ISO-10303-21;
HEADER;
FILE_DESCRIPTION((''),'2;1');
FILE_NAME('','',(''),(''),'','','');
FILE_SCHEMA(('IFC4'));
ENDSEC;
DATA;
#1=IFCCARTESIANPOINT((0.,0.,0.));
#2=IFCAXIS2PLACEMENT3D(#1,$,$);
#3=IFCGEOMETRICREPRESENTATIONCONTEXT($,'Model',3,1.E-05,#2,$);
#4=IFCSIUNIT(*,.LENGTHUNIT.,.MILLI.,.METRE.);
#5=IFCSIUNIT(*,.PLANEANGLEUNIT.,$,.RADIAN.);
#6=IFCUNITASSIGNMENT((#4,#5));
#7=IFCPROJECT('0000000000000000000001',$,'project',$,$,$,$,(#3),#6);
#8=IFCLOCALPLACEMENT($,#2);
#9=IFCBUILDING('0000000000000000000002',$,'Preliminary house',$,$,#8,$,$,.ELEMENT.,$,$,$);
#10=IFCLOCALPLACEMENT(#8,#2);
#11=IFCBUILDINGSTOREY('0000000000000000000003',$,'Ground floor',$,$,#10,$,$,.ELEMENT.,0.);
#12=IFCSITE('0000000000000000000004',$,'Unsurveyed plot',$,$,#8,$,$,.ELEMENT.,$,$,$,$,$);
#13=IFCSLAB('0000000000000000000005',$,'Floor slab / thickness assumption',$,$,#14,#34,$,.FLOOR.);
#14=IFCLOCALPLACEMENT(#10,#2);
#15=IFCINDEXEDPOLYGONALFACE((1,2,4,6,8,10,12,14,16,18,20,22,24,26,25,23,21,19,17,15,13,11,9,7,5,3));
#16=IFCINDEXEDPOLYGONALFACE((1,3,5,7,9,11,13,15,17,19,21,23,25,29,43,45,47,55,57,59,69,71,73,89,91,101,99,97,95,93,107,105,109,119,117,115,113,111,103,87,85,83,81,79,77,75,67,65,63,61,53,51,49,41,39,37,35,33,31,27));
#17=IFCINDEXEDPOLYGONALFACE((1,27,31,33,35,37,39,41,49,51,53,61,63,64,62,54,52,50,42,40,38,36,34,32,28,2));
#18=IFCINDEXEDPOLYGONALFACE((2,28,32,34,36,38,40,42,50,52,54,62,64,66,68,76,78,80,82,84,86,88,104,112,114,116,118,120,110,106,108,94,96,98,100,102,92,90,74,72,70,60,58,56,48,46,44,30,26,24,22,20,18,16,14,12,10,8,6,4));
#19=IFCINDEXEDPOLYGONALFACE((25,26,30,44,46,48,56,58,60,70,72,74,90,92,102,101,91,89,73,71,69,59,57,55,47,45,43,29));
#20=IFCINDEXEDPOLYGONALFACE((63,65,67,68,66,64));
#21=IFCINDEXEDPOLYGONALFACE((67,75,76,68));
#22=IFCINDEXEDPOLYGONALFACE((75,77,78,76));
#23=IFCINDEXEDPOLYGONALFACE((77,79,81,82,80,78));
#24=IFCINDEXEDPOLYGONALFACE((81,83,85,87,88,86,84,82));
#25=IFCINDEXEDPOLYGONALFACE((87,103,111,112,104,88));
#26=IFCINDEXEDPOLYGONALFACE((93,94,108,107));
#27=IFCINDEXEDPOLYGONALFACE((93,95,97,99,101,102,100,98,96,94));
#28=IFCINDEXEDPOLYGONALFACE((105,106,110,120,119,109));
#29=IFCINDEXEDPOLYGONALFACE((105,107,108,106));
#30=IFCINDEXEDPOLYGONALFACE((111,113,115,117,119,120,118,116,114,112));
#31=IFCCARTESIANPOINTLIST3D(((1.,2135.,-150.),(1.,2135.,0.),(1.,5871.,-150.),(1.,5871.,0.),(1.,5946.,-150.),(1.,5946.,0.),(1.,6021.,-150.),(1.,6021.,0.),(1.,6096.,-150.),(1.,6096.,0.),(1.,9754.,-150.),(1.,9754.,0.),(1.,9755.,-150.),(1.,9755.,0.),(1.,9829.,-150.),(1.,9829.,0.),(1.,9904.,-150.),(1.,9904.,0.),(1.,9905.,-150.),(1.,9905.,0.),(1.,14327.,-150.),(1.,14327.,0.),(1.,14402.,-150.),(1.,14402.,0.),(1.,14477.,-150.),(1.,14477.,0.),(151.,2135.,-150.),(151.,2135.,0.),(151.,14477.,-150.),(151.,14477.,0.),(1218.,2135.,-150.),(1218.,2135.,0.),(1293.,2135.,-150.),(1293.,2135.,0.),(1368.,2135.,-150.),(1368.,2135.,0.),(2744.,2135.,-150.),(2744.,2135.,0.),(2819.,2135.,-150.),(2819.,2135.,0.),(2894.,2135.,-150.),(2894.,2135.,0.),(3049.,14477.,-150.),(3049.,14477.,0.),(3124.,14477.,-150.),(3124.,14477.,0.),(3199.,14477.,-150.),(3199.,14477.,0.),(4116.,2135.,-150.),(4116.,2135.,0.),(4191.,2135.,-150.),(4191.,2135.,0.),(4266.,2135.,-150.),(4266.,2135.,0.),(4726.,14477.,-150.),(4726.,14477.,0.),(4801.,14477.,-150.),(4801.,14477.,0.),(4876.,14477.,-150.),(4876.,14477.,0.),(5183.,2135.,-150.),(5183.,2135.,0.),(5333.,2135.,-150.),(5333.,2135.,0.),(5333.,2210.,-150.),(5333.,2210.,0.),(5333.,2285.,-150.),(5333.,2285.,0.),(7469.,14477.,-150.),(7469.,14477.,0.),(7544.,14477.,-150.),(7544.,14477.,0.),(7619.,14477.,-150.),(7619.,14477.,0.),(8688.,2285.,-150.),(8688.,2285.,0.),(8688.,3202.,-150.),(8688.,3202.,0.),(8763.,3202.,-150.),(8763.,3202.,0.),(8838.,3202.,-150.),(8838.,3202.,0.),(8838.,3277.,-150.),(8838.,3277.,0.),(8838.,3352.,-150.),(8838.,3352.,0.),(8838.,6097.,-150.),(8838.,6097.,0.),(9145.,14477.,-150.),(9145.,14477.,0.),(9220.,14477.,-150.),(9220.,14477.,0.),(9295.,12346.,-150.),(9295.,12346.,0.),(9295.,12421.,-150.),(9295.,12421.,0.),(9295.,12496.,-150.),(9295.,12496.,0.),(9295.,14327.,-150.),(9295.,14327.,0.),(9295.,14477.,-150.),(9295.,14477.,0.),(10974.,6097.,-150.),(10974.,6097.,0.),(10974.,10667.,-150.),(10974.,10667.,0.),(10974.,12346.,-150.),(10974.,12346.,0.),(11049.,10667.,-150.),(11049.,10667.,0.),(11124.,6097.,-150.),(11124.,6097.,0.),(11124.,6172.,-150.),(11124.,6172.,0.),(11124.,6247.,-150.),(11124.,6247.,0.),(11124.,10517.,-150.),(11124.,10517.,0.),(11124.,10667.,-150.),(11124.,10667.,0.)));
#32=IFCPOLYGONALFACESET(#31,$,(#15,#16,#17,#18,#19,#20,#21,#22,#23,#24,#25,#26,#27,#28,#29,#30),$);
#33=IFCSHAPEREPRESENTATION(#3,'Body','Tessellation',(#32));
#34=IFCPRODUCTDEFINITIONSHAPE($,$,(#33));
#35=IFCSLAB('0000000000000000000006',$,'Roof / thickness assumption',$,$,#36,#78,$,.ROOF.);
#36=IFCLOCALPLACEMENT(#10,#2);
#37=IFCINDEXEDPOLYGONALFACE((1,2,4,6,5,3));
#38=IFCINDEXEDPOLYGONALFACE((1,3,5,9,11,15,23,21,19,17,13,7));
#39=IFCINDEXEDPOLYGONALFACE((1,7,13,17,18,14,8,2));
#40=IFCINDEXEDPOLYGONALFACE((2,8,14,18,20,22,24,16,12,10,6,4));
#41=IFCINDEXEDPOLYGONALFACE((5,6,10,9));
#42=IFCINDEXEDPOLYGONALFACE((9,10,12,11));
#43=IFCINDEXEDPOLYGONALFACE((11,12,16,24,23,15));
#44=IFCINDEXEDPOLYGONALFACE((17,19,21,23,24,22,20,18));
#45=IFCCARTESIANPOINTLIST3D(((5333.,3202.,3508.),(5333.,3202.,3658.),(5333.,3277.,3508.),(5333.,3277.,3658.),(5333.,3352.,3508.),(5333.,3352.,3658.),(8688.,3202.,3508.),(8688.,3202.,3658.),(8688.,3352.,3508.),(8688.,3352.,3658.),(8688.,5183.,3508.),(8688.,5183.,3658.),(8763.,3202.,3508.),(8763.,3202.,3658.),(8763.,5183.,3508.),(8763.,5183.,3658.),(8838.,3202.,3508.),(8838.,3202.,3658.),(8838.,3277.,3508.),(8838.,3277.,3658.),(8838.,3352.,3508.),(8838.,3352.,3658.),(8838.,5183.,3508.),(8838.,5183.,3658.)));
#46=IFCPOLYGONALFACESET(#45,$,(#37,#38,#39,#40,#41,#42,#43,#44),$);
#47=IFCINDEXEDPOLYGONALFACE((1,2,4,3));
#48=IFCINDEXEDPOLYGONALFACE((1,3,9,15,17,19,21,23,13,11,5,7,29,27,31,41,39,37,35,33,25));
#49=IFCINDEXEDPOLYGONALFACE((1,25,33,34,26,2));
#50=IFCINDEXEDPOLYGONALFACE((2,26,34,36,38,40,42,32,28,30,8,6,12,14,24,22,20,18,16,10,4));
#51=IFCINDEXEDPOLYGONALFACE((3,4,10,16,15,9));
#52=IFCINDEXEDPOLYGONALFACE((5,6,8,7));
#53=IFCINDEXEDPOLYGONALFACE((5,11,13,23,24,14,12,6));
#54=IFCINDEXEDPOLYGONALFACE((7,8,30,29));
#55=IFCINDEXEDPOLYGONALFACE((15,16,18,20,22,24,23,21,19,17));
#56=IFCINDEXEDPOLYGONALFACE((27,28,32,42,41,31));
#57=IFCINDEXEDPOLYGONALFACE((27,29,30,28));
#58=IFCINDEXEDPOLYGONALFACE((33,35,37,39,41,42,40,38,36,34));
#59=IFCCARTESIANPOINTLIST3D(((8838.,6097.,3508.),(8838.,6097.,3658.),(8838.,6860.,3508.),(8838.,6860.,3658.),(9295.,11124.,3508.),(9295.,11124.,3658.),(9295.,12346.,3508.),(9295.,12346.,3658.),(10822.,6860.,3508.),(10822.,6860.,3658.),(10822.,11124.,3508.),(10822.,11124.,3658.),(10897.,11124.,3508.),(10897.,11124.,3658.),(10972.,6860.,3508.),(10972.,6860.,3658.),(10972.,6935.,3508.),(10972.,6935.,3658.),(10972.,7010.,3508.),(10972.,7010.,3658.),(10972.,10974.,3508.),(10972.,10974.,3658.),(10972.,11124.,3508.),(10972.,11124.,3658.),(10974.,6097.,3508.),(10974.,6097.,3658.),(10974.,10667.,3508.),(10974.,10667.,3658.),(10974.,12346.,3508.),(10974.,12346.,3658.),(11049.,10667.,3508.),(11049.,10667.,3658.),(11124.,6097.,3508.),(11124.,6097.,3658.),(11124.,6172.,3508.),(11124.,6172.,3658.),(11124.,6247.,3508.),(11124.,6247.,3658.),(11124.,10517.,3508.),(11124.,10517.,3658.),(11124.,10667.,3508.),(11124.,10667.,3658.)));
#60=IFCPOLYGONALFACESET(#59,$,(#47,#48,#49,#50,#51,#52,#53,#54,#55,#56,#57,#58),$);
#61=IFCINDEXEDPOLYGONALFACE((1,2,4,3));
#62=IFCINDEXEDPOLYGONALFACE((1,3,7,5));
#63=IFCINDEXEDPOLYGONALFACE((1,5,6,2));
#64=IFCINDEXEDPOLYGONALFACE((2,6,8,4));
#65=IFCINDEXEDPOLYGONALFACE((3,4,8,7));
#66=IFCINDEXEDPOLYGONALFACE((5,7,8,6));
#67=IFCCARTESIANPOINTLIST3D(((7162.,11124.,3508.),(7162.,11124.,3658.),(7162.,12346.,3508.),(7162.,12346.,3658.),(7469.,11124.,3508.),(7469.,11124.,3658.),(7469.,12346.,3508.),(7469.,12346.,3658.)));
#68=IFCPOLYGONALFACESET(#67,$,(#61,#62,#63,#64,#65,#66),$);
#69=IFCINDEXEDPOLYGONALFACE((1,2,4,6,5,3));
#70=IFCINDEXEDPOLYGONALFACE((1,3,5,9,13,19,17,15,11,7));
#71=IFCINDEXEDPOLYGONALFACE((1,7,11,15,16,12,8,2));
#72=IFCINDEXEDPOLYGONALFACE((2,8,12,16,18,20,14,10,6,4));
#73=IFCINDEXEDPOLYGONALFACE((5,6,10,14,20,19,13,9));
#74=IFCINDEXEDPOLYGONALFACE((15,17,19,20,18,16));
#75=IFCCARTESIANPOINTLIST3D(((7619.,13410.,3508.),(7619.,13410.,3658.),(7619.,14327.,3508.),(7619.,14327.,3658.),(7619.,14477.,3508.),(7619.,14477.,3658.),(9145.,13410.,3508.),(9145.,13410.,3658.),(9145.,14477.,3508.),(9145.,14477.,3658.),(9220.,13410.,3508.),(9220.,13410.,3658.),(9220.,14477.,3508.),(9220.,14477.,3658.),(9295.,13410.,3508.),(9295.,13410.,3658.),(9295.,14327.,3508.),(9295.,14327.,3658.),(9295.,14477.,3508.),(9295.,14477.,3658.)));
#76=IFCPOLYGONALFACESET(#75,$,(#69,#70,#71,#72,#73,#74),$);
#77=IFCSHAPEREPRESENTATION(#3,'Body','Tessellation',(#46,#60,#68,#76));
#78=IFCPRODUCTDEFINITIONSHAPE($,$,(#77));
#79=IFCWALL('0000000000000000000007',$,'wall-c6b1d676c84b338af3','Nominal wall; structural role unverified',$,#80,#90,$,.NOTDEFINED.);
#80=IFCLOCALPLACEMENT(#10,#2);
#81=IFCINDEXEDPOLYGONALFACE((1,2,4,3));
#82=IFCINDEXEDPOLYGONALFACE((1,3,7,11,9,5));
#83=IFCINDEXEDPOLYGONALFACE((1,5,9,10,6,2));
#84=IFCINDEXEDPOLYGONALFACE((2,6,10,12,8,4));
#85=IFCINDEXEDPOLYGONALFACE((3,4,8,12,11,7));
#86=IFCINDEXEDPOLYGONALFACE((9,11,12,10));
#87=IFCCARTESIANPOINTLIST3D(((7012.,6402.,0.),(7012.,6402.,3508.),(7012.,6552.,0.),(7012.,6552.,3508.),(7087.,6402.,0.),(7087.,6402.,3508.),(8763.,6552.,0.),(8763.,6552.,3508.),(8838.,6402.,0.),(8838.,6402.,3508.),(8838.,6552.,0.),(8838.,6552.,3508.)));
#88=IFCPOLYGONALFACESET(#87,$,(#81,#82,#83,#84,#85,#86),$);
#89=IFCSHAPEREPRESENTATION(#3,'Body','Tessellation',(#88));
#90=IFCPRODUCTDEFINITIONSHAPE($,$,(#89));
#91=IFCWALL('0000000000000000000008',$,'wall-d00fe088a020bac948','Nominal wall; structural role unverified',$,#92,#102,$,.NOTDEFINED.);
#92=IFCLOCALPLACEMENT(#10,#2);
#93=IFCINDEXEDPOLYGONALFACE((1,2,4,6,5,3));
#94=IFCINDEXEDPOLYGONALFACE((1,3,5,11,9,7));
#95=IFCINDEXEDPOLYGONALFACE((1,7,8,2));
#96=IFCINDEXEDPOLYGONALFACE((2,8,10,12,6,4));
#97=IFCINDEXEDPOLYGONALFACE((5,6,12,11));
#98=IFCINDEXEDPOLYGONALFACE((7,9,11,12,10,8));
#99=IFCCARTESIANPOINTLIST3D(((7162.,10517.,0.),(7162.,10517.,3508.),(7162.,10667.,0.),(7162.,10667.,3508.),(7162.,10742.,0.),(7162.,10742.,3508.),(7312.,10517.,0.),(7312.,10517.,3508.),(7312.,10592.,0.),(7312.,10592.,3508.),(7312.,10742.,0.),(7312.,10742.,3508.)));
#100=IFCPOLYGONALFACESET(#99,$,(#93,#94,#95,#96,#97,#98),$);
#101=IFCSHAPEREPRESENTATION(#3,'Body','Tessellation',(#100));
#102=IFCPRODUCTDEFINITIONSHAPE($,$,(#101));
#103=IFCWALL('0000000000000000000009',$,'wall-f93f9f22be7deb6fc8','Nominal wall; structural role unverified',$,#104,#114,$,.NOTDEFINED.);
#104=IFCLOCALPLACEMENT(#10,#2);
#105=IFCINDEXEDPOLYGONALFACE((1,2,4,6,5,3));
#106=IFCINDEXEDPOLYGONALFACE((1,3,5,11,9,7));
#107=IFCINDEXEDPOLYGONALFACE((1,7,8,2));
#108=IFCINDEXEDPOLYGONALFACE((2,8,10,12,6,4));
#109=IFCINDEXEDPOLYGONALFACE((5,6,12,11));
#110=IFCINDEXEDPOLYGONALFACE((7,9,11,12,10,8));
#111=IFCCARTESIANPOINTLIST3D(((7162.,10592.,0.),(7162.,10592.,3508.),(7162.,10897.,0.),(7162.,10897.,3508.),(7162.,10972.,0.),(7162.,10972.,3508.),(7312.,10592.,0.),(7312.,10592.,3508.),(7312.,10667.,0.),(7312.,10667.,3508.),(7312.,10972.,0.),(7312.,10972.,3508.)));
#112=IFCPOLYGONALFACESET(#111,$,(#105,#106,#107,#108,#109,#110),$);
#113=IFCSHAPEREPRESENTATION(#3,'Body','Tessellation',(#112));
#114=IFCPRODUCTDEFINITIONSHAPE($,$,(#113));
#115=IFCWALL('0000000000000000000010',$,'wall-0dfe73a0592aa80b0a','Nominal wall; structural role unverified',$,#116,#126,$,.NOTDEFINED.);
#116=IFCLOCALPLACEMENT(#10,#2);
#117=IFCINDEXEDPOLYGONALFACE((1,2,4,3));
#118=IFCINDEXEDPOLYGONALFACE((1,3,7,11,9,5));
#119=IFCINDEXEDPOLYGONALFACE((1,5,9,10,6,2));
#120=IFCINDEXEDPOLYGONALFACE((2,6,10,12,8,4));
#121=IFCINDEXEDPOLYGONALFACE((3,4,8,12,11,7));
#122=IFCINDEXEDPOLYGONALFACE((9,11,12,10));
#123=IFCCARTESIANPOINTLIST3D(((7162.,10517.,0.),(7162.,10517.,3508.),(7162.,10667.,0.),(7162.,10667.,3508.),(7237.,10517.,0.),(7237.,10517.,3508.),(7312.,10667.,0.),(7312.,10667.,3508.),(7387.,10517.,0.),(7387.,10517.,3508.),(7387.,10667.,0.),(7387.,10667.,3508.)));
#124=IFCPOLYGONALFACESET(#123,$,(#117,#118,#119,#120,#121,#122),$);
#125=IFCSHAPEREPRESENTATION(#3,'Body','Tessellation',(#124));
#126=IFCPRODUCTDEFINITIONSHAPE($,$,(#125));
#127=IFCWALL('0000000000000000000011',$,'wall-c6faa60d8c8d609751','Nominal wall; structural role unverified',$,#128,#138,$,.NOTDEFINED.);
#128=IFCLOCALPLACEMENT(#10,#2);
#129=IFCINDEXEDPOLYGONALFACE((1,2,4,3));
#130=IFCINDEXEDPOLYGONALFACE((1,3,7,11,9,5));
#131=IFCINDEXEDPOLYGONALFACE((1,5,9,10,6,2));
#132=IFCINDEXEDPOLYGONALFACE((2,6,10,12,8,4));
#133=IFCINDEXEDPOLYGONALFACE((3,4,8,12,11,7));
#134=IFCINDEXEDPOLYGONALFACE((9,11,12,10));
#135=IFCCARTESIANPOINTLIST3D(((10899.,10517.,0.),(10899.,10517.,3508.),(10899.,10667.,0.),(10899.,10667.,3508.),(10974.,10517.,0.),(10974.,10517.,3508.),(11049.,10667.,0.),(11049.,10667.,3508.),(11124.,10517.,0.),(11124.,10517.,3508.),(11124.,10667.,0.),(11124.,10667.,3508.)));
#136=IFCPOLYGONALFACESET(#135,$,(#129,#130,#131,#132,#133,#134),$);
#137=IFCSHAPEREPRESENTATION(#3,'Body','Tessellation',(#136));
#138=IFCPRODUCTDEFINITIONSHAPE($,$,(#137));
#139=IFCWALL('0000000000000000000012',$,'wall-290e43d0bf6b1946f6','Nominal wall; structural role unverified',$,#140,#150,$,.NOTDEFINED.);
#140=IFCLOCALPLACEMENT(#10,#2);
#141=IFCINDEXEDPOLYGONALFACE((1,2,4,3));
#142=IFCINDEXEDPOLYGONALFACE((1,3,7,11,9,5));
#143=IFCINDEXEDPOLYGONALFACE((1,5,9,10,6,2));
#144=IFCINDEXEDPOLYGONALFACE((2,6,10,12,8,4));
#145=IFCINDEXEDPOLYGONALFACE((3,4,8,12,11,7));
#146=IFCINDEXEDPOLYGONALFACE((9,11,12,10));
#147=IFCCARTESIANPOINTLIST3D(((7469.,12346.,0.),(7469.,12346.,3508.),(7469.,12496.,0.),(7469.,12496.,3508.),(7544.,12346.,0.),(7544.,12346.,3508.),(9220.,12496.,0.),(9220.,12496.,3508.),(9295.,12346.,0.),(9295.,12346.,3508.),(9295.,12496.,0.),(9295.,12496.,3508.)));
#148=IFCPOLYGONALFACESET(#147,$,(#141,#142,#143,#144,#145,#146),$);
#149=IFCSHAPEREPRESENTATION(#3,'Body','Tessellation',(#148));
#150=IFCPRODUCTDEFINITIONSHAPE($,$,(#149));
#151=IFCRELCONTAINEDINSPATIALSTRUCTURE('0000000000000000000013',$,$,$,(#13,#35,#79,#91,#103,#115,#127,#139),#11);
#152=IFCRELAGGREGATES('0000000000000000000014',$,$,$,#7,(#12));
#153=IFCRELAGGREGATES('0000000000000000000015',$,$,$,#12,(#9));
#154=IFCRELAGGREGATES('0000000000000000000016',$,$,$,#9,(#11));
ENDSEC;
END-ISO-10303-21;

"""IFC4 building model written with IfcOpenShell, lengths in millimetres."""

from ifc_helpers import new_model, si_unit, frame, origin, place, context, project, spatial, polyline, outline, extrude, element, save


model = new_model("IFC4")

# Units and contexts
model_context = context("Model", 3, precision=1e-05, world=origin())
ifc_project = project(units=[si_unit("LENGTHUNIT", "METRE", prefix="MILLI"), si_unit("PLANEANGLEUNIT", "RADIAN")], contexts=[model_context])

# Site, building, storey
placement_1 = place(None, origin())
site = spatial("IfcSite", under=ifc_project, at=placement_1, Name="Unsurveyed plot", CompositionType="ELEMENT")
building = spatial("IfcBuilding", under=site, at=placement_1, Name="Preliminary house", CompositionType="ELEMENT")
placement_2 = place(placement_1, origin())
storey = spatial("IfcBuildingStorey", under=building, at=placement_2, Name="Ground floor", CompositionType="ELEMENT", Elevation=0.0)

# Slabs
element("IfcSlab", 1, at=placement_2, inside=storey, Name="Floor slab / thickness assumption", PredefinedType="FLOOR", context=model_context, shape_type="SweptSolid", body=[
    extrude(outline(polyline([(1368.0, 2135.0), (1293.0, 2135.0), (1218.0, 2135.0), (151.0, 2135.0), (1.0, 2135.0), (1.0, 5871.0), (1.0, 5946.0), (1.0, 6021.0), (1.0, 6096.0), (1.0, 9754.0), (1.0, 9755.0), (1.0, 9829.0), (1.0, 9904.0), (1.0, 9905.0), (1.0, 14327.0), (1.0, 14402.0), (1.0, 14477.0), (151.0, 14477.0), (3049.0, 14477.0), (3124.0, 14477.0), (3199.0, 14477.0), (4726.0, 14477.0), (4801.0, 14477.0), (4876.0, 14477.0), (7469.0, 14477.0), (7544.0, 14477.0), (7619.0, 14477.0), (9145.0, 14477.0), (9220.0, 14477.0), (9295.0, 14477.0), (9295.0, 14327.0), (9295.0, 12496.0), (9295.0, 12421.0), (9295.0, 12346.0), (10974.0, 12346.0), (10974.0, 10667.0), (11049.0, 10667.0), (11124.0, 10667.0), (11124.0, 10517.0), (11124.0, 6247.0), (11124.0, 6172.0), (11124.0, 6097.0), (10974.0, 6097.0), (8838.0, 6097.0), (8838.0, 3352.0), (8838.0, 3277.0), (8838.0, 3202.0), (8763.0, 3202.0), (8688.0, 3202.0), (8688.0, 2285.0), (5333.0, 2285.0), (5333.0, 2210.0), (5333.0, 2135.0), (5183.0, 2135.0), (4266.0, 2135.0), (4191.0, 2135.0), (4116.0, 2135.0), (2894.0, 2135.0), (2819.0, 2135.0), (2744.0, 2135.0), (1368.0, 2135.0)])), frame((0.0, 0.0, -150.0)), (0.0, 0.0, 1.0), 150.0),
])
element("IfcSlab", 2, at=placement_2, inside=storey, Name="Roof / thickness assumption", PredefinedType="ROOF", context=model_context, shape_type="SweptSolid", body=[
    extrude(outline(polyline([(8838.0, 3202.0), (8763.0, 3202.0), (8688.0, 3202.0), (5333.0, 3202.0), (5333.0, 3277.0), (5333.0, 3352.0), (8688.0, 3352.0), (8688.0, 5183.0), (8763.0, 5183.0), (8838.0, 5183.0), (8838.0, 3352.0), (8838.0, 3277.0), (8838.0, 3202.0)])), frame((0.0, 0.0, 3508.0)), (0.0, 0.0, 1.0), 150.0),
    extrude(outline(polyline([(11049.0, 10667.0), (11124.0, 10667.0), (11124.0, 10517.0), (11124.0, 6247.0), (11124.0, 6172.0), (11124.0, 6097.0), (10974.0, 6097.0), (8838.0, 6097.0), (8838.0, 6860.0), (10822.0, 6860.0), (10972.0, 6860.0), (10972.0, 6935.0), (10972.0, 7010.0), (10972.0, 10974.0), (10972.0, 11124.0), (10897.0, 11124.0), (10822.0, 11124.0), (9295.0, 11124.0), (9295.0, 12346.0), (10974.0, 12346.0), (10974.0, 10667.0), (11049.0, 10667.0)])), frame((0.0, 0.0, 3508.0)), (0.0, 0.0, 1.0), 150.0),
    extrude(outline(polyline([(7162.0, 11124.0), (7162.0, 12346.0), (7469.0, 12346.0), (7469.0, 11124.0), (7162.0, 11124.0)])), frame((0.0, 0.0, 3508.0)), (0.0, 0.0, 1.0), 150.0),
    extrude(outline(polyline([(9295.0, 14477.0), (9295.0, 14327.0), (9295.0, 13410.0), (9220.0, 13410.0), (9145.0, 13410.0), (7619.0, 13410.0), (7619.0, 14327.0), (7619.0, 14477.0), (9145.0, 14477.0), (9220.0, 14477.0), (9295.0, 14477.0)])), frame((0.0, 0.0, 3508.0)), (0.0, 0.0, 1.0), 150.0),
])

# Walls
element("IfcWall", 3, at=placement_2, inside=storey, Name="wall-c6b1d676c84b338af3", Description="Nominal wall; structural role unverified", PredefinedType="NOTDEFINED", context=model_context, shape_type="SweptSolid", body=[
    extrude(outline(polyline([(8763.0, 6552.0), (8838.0, 6552.0), (8838.0, 6402.0), (7087.0, 6402.0), (7012.0, 6402.0), (7012.0, 6552.0), (8763.0, 6552.0)])), origin(), (0.0, 0.0, 1.0), 3508.0),
])
element("IfcWall", 4, at=placement_2, inside=storey, Name="wall-d00fe088a020bac948", Description="Nominal wall; structural role unverified", PredefinedType="NOTDEFINED", context=model_context, shape_type="SweptSolid", body=[
    extrude(outline(polyline([(7162.0, 10667.0), (7162.0, 10742.0), (7312.0, 10742.0), (7312.0, 10592.0), (7312.0, 10517.0), (7162.0, 10517.0), (7162.0, 10667.0)])), origin(), (0.0, 0.0, 1.0), 3508.0),
])
element("IfcWall", 5, at=placement_2, inside=storey, Name="wall-f93f9f22be7deb6fc8", Description="Nominal wall; structural role unverified", PredefinedType="NOTDEFINED", context=model_context, shape_type="SweptSolid", body=[
    extrude(outline(polyline([(7162.0, 10897.0), (7162.0, 10972.0), (7312.0, 10972.0), (7312.0, 10667.0), (7312.0, 10592.0), (7162.0, 10592.0), (7162.0, 10897.0)])), origin(), (0.0, 0.0, 1.0), 3508.0),
])
element("IfcWall", 6, at=placement_2, inside=storey, Name="wall-0dfe73a0592aa80b0a", Description="Nominal wall; structural role unverified", PredefinedType="NOTDEFINED", context=model_context, shape_type="SweptSolid", body=[
    extrude(outline(polyline([(7312.0, 10667.0), (7387.0, 10667.0), (7387.0, 10517.0), (7237.0, 10517.0), (7162.0, 10517.0), (7162.0, 10667.0), (7312.0, 10667.0)])), origin(), (0.0, 0.0, 1.0), 3508.0),
])

# Wall
element("IfcWall", 7, at=placement_2, inside=storey, Name="wall-c6faa60d8c8d609751", Description="Nominal wall; structural role unverified", PredefinedType="NOTDEFINED", context=model_context, shape_type="SweptSolid", body=[
    extrude(outline(polyline([(11049.0, 10667.0), (11124.0, 10667.0), (11124.0, 10517.0), (10974.0, 10517.0), (10899.0, 10517.0), (10899.0, 10667.0), (11049.0, 10667.0)])), origin(), (0.0, 0.0, 1.0), 3508.0),
])

# Wall
element("IfcWall", 8, at=placement_2, inside=storey, Name="wall-290e43d0bf6b1946f6", Description="Nominal wall; structural role unverified", PredefinedType="NOTDEFINED", context=model_context, shape_type="SweptSolid", body=[
    extrude(outline(polyline([(9220.0, 12496.0), (9295.0, 12496.0), (9295.0, 12346.0), (7544.0, 12346.0), (7469.0, 12346.0), (7469.0, 12496.0), (9220.0, 12496.0)])), origin(), (0.0, 0.0, 1.0), 3508.0),
])

save(model, "model.ifc")
